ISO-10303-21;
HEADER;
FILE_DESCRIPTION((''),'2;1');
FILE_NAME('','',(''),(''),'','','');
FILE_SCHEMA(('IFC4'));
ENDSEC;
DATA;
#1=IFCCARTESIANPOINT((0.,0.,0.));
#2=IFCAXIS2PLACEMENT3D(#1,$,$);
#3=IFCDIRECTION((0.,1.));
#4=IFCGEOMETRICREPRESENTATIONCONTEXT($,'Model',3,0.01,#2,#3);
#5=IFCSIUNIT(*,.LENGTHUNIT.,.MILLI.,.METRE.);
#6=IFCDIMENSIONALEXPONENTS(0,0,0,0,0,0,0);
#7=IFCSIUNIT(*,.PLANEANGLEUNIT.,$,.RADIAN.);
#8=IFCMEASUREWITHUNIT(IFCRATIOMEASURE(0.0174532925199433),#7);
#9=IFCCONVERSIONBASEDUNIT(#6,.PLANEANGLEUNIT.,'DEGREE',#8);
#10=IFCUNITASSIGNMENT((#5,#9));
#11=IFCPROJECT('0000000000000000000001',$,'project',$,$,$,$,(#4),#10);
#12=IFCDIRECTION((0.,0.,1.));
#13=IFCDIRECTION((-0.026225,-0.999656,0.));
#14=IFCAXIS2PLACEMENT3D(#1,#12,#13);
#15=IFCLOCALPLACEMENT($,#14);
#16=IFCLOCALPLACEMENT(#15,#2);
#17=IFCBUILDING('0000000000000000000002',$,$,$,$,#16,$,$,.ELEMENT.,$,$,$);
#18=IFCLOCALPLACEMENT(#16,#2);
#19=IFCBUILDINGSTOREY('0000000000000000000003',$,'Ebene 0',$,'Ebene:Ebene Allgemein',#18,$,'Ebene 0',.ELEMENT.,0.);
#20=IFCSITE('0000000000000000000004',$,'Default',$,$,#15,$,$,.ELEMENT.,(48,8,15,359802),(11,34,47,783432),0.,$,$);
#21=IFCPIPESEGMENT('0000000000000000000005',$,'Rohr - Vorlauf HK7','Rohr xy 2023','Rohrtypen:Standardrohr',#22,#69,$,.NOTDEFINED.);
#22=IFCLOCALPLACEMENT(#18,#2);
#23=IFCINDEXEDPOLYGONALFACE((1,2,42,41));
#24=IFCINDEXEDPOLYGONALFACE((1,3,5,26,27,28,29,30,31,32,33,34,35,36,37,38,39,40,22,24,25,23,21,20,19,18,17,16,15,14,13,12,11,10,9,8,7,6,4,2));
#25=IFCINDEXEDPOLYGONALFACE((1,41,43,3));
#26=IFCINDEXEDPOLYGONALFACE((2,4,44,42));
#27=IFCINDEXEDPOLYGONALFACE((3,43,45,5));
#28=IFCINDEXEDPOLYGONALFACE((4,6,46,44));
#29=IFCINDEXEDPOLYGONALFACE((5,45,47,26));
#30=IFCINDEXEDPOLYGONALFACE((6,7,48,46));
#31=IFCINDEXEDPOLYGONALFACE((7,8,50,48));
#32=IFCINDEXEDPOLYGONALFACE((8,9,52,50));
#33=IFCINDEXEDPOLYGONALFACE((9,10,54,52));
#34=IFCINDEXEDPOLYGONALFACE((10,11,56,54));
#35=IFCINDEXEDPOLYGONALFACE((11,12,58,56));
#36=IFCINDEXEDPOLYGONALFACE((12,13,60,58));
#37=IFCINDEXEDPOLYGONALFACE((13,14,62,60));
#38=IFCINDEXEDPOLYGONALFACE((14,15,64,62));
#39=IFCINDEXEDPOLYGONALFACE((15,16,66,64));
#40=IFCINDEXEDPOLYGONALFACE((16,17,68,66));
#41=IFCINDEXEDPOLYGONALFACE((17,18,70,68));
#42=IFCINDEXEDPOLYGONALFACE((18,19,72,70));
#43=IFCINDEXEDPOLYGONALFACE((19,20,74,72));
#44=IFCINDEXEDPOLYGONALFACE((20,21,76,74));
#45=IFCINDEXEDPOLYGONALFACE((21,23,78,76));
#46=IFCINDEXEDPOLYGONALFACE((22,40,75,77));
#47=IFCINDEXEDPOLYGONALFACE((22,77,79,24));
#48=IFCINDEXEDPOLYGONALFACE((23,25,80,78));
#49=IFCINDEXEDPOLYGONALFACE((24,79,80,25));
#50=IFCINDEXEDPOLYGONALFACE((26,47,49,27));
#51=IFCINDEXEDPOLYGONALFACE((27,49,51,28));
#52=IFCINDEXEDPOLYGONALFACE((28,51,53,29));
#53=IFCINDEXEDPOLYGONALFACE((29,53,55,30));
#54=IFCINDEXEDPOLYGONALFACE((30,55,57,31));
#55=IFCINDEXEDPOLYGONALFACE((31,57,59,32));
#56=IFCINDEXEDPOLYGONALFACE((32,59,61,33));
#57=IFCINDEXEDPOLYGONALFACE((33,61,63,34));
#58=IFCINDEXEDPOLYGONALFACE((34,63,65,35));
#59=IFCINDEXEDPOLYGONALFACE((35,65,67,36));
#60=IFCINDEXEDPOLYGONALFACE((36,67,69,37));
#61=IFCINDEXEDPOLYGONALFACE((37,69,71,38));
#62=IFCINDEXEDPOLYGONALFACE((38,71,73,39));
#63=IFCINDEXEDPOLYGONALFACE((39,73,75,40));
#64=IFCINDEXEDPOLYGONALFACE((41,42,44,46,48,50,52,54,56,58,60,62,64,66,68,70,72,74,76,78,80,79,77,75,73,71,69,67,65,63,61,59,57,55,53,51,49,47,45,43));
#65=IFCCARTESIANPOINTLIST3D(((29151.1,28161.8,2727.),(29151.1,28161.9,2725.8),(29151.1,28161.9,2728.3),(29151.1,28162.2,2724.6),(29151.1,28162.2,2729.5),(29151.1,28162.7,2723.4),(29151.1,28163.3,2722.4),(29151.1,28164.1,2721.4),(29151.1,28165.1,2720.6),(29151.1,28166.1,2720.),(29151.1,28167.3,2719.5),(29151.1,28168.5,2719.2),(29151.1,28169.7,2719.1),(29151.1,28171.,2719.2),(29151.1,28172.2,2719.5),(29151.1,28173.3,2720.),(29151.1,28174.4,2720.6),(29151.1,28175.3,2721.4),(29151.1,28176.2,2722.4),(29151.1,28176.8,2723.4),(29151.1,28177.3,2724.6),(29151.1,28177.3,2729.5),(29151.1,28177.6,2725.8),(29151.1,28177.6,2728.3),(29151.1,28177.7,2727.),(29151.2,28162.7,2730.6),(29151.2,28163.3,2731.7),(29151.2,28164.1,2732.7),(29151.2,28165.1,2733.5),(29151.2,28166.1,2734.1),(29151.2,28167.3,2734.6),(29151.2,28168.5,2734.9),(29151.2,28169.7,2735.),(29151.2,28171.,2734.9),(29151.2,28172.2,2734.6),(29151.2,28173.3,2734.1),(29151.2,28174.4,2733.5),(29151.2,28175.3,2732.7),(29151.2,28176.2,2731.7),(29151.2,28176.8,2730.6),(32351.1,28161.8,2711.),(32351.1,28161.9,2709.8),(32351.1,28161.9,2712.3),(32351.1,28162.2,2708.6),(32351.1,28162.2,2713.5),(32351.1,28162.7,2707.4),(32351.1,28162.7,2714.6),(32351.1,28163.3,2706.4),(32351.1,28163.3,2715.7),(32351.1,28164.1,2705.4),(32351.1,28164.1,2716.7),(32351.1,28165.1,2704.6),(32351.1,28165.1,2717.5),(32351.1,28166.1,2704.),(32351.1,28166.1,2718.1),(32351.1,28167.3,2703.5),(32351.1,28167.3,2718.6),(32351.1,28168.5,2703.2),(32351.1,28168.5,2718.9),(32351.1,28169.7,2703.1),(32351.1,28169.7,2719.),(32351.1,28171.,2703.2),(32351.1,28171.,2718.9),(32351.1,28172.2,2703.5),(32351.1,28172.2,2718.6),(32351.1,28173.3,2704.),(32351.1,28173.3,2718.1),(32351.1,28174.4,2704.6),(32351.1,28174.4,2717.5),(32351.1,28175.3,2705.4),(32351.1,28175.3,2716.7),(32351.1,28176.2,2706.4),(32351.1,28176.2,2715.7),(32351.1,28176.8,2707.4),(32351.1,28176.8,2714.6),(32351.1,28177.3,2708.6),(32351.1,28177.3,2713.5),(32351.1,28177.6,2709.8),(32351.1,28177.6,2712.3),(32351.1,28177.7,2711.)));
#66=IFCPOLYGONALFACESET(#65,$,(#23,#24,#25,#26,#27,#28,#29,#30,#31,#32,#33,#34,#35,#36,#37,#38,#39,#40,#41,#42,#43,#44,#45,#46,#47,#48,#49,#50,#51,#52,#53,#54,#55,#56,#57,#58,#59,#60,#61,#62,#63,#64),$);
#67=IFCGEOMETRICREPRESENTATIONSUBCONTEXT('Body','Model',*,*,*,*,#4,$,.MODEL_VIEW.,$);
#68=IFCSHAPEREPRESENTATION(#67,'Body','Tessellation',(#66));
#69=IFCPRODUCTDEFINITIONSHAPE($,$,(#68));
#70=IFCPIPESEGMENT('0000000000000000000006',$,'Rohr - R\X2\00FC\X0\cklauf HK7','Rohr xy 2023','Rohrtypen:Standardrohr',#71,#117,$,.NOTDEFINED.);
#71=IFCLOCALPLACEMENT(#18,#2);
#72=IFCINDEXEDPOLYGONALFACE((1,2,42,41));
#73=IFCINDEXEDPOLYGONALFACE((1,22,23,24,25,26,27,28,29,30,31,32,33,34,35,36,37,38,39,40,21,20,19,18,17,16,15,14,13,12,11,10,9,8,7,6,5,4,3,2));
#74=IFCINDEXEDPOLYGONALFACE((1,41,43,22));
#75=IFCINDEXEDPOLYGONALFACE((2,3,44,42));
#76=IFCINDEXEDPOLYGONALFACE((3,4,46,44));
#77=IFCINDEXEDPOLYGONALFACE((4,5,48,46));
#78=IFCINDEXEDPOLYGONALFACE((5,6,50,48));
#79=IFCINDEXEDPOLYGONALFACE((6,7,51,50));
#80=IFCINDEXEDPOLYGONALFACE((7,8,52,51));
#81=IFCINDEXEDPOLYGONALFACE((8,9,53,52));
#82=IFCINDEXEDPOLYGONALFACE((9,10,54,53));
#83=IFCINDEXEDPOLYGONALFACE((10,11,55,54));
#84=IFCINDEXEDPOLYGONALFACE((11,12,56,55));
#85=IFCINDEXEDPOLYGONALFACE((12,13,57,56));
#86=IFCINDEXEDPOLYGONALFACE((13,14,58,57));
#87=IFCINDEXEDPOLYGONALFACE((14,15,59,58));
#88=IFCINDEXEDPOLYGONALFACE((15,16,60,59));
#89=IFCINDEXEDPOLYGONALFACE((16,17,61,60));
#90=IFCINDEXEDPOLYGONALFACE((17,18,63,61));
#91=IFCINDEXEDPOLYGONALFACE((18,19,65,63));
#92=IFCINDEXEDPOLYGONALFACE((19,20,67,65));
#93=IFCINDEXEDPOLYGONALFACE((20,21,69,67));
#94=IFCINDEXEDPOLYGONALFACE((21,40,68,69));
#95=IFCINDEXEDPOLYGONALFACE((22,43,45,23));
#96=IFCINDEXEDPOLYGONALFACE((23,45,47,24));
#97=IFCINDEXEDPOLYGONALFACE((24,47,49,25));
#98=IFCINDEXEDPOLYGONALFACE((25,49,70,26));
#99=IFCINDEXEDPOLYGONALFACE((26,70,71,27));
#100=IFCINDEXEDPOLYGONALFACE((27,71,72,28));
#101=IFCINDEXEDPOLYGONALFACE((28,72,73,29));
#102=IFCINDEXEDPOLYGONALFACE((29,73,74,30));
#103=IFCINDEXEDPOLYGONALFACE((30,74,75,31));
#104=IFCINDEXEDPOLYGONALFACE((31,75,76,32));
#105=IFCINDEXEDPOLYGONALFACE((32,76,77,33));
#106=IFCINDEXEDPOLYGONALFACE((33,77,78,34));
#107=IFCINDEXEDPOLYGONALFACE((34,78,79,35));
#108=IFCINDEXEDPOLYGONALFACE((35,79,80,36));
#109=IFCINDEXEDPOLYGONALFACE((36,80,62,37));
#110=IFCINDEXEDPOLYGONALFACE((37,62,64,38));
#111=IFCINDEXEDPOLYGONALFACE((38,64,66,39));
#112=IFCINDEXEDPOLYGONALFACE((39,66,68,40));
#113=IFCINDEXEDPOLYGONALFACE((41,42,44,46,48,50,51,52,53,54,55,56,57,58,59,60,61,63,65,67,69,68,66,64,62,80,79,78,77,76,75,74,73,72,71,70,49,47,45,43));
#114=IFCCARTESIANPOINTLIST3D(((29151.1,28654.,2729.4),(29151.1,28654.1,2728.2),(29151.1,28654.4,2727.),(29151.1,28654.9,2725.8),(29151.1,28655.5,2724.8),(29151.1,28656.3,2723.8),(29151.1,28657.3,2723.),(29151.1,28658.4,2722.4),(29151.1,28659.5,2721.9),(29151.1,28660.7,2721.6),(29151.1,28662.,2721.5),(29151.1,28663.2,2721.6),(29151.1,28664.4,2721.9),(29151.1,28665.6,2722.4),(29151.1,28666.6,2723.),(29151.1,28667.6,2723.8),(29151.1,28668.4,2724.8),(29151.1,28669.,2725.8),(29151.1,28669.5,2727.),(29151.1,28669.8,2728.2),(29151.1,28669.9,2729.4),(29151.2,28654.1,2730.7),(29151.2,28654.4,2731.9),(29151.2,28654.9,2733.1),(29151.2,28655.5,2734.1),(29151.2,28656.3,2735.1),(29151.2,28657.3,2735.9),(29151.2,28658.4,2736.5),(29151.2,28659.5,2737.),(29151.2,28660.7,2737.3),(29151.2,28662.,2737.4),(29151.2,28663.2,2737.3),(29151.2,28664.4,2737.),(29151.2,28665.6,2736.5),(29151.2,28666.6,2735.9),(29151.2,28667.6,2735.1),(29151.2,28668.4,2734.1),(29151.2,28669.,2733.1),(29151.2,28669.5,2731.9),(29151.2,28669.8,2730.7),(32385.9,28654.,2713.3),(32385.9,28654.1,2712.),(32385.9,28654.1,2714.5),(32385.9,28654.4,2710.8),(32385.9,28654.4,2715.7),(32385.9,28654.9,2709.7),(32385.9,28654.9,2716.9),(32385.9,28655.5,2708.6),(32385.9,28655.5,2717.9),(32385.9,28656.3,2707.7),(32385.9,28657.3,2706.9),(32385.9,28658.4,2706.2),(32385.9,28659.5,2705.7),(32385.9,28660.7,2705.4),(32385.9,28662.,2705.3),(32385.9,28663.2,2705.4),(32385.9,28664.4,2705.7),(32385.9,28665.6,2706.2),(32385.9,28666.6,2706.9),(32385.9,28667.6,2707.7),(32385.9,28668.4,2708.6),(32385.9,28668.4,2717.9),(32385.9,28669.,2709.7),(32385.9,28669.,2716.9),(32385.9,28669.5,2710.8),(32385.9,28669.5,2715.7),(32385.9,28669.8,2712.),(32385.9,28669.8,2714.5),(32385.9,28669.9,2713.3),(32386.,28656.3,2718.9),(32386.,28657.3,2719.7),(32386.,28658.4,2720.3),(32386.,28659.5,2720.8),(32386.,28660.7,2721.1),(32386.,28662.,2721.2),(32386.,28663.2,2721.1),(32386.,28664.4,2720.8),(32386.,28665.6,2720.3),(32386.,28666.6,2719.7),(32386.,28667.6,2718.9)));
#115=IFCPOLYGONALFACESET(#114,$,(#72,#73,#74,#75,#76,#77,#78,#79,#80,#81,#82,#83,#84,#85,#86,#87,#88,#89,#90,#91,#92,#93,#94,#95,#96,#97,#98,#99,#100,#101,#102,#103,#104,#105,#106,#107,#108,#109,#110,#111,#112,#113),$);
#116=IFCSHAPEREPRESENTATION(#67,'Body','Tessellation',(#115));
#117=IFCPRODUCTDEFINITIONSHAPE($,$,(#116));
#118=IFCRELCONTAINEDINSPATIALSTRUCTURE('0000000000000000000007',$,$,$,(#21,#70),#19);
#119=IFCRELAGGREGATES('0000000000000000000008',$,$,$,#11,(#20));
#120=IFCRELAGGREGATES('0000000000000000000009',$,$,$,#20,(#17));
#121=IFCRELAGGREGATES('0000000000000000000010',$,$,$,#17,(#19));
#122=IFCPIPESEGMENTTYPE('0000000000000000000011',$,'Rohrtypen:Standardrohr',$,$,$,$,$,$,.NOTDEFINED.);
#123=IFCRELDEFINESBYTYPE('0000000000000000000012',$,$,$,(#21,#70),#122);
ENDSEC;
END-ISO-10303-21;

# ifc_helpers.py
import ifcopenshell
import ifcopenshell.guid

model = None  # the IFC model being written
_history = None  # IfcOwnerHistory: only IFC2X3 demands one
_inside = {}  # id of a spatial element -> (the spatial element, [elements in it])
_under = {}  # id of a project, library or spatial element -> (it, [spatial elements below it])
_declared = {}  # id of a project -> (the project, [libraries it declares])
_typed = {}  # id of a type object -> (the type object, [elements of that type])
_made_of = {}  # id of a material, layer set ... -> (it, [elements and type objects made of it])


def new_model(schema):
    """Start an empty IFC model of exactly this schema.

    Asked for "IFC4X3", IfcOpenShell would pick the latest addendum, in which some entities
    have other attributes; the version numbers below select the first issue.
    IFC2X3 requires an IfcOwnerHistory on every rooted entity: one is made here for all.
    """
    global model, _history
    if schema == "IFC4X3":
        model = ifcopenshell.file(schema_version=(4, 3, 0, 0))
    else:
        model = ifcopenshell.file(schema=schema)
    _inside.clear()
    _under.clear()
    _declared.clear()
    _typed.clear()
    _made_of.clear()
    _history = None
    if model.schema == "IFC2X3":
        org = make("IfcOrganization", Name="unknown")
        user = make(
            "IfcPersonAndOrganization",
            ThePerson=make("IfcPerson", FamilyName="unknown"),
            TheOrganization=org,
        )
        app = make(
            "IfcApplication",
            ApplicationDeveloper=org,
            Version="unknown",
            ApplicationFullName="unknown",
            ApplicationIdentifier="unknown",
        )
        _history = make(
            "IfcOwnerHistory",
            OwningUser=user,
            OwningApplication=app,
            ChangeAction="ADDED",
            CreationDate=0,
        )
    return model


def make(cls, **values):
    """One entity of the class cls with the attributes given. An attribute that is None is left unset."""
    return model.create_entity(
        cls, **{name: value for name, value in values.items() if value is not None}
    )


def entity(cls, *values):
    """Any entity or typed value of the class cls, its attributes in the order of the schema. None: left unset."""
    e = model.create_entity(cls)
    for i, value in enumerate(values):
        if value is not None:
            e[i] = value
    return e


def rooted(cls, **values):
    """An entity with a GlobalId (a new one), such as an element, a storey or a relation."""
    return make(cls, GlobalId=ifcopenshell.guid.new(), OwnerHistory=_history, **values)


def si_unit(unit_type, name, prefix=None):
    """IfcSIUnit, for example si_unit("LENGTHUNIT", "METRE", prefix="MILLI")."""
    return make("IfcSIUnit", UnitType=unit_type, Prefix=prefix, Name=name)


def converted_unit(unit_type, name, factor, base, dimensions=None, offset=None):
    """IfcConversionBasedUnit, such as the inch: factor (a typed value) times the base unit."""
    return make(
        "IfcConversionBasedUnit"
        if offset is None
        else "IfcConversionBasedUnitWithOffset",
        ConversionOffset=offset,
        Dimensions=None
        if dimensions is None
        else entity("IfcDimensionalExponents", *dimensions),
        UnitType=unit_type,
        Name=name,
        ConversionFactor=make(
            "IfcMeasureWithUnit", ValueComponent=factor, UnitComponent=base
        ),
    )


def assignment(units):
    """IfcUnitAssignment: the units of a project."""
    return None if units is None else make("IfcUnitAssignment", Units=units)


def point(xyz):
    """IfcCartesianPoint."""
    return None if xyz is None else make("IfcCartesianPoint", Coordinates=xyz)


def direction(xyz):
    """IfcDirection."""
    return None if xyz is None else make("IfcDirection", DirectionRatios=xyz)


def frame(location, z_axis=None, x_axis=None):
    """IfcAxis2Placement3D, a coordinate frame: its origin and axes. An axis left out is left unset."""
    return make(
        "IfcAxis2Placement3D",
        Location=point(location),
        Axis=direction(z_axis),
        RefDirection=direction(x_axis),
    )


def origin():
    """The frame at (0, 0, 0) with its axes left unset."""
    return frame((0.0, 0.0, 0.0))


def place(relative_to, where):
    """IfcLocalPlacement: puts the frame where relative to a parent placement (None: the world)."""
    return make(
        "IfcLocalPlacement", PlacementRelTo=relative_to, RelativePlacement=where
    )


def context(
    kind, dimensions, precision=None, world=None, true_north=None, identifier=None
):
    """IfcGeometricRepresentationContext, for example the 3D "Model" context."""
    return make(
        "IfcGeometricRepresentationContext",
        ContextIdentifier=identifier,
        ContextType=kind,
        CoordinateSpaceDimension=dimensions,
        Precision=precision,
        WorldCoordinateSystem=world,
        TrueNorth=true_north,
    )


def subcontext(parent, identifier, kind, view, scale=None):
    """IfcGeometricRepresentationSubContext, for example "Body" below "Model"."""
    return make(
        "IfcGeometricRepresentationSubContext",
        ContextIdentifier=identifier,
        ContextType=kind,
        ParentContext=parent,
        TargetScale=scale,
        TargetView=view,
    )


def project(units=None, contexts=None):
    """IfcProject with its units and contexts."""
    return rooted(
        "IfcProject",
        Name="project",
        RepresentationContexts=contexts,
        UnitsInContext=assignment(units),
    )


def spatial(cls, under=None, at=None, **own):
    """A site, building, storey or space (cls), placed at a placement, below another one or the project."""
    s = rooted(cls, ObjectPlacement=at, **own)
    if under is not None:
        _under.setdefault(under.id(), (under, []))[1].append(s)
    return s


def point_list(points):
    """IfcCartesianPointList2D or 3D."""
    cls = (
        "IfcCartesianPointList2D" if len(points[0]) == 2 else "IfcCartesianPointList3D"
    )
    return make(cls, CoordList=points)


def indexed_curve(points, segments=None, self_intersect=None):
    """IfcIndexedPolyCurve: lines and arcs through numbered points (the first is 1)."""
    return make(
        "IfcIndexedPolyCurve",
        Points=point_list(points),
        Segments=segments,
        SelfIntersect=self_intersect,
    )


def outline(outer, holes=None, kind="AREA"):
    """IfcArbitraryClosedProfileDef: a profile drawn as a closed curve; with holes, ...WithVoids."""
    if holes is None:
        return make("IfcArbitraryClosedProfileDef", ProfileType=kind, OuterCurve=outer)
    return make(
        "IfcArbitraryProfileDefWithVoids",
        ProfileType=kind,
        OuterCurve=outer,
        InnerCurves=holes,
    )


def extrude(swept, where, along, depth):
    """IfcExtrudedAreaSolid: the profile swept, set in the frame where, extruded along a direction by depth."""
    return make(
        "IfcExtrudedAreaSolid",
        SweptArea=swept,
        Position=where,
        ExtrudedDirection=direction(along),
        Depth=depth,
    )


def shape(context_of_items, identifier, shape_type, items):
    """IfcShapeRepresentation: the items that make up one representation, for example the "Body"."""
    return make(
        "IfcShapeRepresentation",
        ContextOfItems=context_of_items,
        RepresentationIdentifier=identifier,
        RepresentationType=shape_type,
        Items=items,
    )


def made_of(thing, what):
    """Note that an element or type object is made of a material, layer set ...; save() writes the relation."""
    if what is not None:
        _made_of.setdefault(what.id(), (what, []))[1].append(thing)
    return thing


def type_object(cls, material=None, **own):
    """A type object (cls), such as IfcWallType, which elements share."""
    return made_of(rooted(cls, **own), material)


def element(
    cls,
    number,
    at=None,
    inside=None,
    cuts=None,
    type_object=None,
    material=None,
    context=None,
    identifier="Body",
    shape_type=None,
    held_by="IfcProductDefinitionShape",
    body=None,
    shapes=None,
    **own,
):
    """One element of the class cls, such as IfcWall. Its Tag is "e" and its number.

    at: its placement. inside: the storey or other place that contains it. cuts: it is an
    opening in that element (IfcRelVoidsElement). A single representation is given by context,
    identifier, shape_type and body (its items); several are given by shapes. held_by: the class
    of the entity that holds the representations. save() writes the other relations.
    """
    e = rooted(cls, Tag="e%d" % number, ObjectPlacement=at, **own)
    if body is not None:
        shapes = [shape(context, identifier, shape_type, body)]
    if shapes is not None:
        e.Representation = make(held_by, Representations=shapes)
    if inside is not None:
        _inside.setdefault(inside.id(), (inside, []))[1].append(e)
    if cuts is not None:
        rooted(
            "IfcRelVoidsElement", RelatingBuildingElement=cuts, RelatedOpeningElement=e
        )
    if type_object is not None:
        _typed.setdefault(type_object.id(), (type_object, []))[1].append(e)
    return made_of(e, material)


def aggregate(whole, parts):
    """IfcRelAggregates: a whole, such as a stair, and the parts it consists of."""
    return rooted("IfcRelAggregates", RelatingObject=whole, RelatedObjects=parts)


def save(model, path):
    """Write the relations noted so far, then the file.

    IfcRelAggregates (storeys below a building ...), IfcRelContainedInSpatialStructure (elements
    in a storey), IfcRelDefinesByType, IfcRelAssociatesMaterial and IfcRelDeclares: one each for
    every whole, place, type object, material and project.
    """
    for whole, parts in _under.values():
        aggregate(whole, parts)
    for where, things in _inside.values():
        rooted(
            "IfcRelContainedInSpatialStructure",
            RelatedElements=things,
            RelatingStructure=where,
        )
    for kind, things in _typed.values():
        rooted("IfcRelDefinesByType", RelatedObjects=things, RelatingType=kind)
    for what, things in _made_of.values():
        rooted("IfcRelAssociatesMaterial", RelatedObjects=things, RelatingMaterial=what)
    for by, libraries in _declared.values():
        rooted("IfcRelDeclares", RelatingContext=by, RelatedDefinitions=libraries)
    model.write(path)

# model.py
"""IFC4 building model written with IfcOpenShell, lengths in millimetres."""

from ifc_helpers import new_model, entity, si_unit, converted_unit, direction, frame, origin, place, context, subcontext, project, spatial, indexed_curve, outline, extrude, type_object, element, save


model = new_model("IFC4")

# Units and contexts
model_context = context("Model", 3, precision=0.01, world=origin(), true_north=direction((0.0, 1.0)))
body_context = subcontext(model_context, "Body", "Model", "MODEL_VIEW")
ifc_project = project(units=[si_unit("LENGTHUNIT", "METRE", prefix="MILLI"), converted_unit("PLANEANGLEUNIT", "DEGREE", entity("IfcRatioMeasure", 0.0174532925199433), si_unit("PLANEANGLEUNIT", "RADIAN"), dimensions=[0, 0, 0, 0, 0, 0, 0])], contexts=[model_context])

# Site, building, storey
site_placement = place(None, frame((0.0, 0.0, 0.0), z_axis=(0.0, 0.0, 1.0), x_axis=(-0.026225, -0.999656, 0.0)))
site = spatial("IfcSite", under=ifc_project, at=site_placement, Name="Default", CompositionType="ELEMENT", RefLatitude=(48, 8, 15, 359802), RefLongitude=(11, 34, 47, 783432), RefElevation=0.0)
building_placement = place(site_placement, origin())
building = spatial("IfcBuilding", under=site, at=building_placement, CompositionType="ELEMENT")
storey_placement = place(building_placement, origin())
storey = spatial("IfcBuildingStorey", under=building, at=storey_placement, Name="Ebene 0", ObjectType="Ebene:Ebene Allgemein", LongName="Ebene 0", CompositionType="ELEMENT", Elevation=0.0)

# Pipe segments
pipe_segment_type = type_object("IfcPipeSegmentType", Name="Rohrtypen:Standardrohr", PredefinedType="NOTDEFINED")
pipe_segment_1_placement = place(storey_placement, origin())
element("IfcPipeSegment", 1, at=pipe_segment_1_placement, inside=storey, type_object=pipe_segment_type, Name="Rohr - Vorlauf HK7", Description="Rohr xy 2023", ObjectType="Rohrtypen:Standardrohr", PredefinedType="NOTDEFINED", context=body_context, shape_type="SweptSolid", body=[
    extrude(outline(indexed_curve([(7.9, 0.0), (7.8, 1.2), (7.6, 2.5), (7.1, 3.6), (6.4, 4.7), (5.6, 5.6), (4.7, 6.4), (3.6, 7.1), (2.5, 7.6), (1.2, 7.8), (0.0, 7.9), (-1.2, 7.8), (-2.5, 7.6), (-3.6, 7.1), (-4.7, 6.4), (-5.6, 5.6), (-6.4, 4.7), (-7.1, 3.6), (-7.6, 2.5), (-7.8, 1.2), (-7.9, 0.0), (-7.8, -1.2), (-7.6, -2.5), (-7.1, -3.6), (-6.4, -4.7), (-5.6, -5.6), (-4.7, -6.4), (-3.6, -7.1), (-2.5, -7.6), (-1.2, -7.8), (0.0, -7.9), (1.2, -7.8), (2.5, -7.6), (3.6, -7.1), (4.7, -6.4), (5.6, -5.6), (6.4, -4.7), (7.1, -3.6), (7.6, -2.5), (7.8, -1.2), (7.9, 0.0)], self_intersect=False)), frame((32351.1, 28169.7, 2711.0), z_axis=(-0.999988, 0.0, 0.005), x_axis=(0.0, 1.0, 0.0)), (0.0, 0.0, 1.0), 3200.0),
])
pipe_segment_2_placement = place(storey_placement, origin())
element("IfcPipeSegment", 2, at=pipe_segment_2_placement, inside=storey, type_object=pipe_segment_type, Name="Rohr - Rücklauf HK7", Description="Rohr xy 2023", ObjectType="Rohrtypen:Standardrohr", PredefinedType="NOTDEFINED", context=body_context, shape_type="SweptSolid", body=[
    extrude(outline(indexed_curve([(7.9, 0.0), (7.8, 1.2), (7.6, 2.5), (7.1, 3.6), (6.4, 4.7), (5.6, 5.6), (4.7, 6.4), (3.6, 7.1), (2.5, 7.6), (1.2, 7.8), (0.0, 7.9), (-1.2, 7.8), (-2.5, 7.6), (-3.6, 7.1), (-4.7, 6.4), (-5.6, 5.6), (-6.4, 4.7), (-7.1, 3.6), (-7.6, 2.5), (-7.8, 1.2), (-7.9, 0.0), (-7.8, -1.2), (-7.6, -2.5), (-7.1, -3.6), (-6.4, -4.7), (-5.6, -5.6), (-4.7, -6.4), (-3.6, -7.1), (-2.5, -7.6), (-1.2, -7.8), (0.0, -7.9), (1.2, -7.8), (2.5, -7.6), (3.6, -7.1), (4.7, -6.4), (5.6, -5.6), (6.4, -4.7), (7.1, -3.6), (7.6, -2.5), (7.8, -1.2), (7.9, 0.0)], self_intersect=False)), frame((32385.9, 28662.0, 2713.3), z_axis=(-0.999988, 0.0, 0.005), x_axis=(0.0, 1.0, 0.0)), (0.0, 0.0, 1.0), 3234.8),
])

save(model, "model.ifc")
